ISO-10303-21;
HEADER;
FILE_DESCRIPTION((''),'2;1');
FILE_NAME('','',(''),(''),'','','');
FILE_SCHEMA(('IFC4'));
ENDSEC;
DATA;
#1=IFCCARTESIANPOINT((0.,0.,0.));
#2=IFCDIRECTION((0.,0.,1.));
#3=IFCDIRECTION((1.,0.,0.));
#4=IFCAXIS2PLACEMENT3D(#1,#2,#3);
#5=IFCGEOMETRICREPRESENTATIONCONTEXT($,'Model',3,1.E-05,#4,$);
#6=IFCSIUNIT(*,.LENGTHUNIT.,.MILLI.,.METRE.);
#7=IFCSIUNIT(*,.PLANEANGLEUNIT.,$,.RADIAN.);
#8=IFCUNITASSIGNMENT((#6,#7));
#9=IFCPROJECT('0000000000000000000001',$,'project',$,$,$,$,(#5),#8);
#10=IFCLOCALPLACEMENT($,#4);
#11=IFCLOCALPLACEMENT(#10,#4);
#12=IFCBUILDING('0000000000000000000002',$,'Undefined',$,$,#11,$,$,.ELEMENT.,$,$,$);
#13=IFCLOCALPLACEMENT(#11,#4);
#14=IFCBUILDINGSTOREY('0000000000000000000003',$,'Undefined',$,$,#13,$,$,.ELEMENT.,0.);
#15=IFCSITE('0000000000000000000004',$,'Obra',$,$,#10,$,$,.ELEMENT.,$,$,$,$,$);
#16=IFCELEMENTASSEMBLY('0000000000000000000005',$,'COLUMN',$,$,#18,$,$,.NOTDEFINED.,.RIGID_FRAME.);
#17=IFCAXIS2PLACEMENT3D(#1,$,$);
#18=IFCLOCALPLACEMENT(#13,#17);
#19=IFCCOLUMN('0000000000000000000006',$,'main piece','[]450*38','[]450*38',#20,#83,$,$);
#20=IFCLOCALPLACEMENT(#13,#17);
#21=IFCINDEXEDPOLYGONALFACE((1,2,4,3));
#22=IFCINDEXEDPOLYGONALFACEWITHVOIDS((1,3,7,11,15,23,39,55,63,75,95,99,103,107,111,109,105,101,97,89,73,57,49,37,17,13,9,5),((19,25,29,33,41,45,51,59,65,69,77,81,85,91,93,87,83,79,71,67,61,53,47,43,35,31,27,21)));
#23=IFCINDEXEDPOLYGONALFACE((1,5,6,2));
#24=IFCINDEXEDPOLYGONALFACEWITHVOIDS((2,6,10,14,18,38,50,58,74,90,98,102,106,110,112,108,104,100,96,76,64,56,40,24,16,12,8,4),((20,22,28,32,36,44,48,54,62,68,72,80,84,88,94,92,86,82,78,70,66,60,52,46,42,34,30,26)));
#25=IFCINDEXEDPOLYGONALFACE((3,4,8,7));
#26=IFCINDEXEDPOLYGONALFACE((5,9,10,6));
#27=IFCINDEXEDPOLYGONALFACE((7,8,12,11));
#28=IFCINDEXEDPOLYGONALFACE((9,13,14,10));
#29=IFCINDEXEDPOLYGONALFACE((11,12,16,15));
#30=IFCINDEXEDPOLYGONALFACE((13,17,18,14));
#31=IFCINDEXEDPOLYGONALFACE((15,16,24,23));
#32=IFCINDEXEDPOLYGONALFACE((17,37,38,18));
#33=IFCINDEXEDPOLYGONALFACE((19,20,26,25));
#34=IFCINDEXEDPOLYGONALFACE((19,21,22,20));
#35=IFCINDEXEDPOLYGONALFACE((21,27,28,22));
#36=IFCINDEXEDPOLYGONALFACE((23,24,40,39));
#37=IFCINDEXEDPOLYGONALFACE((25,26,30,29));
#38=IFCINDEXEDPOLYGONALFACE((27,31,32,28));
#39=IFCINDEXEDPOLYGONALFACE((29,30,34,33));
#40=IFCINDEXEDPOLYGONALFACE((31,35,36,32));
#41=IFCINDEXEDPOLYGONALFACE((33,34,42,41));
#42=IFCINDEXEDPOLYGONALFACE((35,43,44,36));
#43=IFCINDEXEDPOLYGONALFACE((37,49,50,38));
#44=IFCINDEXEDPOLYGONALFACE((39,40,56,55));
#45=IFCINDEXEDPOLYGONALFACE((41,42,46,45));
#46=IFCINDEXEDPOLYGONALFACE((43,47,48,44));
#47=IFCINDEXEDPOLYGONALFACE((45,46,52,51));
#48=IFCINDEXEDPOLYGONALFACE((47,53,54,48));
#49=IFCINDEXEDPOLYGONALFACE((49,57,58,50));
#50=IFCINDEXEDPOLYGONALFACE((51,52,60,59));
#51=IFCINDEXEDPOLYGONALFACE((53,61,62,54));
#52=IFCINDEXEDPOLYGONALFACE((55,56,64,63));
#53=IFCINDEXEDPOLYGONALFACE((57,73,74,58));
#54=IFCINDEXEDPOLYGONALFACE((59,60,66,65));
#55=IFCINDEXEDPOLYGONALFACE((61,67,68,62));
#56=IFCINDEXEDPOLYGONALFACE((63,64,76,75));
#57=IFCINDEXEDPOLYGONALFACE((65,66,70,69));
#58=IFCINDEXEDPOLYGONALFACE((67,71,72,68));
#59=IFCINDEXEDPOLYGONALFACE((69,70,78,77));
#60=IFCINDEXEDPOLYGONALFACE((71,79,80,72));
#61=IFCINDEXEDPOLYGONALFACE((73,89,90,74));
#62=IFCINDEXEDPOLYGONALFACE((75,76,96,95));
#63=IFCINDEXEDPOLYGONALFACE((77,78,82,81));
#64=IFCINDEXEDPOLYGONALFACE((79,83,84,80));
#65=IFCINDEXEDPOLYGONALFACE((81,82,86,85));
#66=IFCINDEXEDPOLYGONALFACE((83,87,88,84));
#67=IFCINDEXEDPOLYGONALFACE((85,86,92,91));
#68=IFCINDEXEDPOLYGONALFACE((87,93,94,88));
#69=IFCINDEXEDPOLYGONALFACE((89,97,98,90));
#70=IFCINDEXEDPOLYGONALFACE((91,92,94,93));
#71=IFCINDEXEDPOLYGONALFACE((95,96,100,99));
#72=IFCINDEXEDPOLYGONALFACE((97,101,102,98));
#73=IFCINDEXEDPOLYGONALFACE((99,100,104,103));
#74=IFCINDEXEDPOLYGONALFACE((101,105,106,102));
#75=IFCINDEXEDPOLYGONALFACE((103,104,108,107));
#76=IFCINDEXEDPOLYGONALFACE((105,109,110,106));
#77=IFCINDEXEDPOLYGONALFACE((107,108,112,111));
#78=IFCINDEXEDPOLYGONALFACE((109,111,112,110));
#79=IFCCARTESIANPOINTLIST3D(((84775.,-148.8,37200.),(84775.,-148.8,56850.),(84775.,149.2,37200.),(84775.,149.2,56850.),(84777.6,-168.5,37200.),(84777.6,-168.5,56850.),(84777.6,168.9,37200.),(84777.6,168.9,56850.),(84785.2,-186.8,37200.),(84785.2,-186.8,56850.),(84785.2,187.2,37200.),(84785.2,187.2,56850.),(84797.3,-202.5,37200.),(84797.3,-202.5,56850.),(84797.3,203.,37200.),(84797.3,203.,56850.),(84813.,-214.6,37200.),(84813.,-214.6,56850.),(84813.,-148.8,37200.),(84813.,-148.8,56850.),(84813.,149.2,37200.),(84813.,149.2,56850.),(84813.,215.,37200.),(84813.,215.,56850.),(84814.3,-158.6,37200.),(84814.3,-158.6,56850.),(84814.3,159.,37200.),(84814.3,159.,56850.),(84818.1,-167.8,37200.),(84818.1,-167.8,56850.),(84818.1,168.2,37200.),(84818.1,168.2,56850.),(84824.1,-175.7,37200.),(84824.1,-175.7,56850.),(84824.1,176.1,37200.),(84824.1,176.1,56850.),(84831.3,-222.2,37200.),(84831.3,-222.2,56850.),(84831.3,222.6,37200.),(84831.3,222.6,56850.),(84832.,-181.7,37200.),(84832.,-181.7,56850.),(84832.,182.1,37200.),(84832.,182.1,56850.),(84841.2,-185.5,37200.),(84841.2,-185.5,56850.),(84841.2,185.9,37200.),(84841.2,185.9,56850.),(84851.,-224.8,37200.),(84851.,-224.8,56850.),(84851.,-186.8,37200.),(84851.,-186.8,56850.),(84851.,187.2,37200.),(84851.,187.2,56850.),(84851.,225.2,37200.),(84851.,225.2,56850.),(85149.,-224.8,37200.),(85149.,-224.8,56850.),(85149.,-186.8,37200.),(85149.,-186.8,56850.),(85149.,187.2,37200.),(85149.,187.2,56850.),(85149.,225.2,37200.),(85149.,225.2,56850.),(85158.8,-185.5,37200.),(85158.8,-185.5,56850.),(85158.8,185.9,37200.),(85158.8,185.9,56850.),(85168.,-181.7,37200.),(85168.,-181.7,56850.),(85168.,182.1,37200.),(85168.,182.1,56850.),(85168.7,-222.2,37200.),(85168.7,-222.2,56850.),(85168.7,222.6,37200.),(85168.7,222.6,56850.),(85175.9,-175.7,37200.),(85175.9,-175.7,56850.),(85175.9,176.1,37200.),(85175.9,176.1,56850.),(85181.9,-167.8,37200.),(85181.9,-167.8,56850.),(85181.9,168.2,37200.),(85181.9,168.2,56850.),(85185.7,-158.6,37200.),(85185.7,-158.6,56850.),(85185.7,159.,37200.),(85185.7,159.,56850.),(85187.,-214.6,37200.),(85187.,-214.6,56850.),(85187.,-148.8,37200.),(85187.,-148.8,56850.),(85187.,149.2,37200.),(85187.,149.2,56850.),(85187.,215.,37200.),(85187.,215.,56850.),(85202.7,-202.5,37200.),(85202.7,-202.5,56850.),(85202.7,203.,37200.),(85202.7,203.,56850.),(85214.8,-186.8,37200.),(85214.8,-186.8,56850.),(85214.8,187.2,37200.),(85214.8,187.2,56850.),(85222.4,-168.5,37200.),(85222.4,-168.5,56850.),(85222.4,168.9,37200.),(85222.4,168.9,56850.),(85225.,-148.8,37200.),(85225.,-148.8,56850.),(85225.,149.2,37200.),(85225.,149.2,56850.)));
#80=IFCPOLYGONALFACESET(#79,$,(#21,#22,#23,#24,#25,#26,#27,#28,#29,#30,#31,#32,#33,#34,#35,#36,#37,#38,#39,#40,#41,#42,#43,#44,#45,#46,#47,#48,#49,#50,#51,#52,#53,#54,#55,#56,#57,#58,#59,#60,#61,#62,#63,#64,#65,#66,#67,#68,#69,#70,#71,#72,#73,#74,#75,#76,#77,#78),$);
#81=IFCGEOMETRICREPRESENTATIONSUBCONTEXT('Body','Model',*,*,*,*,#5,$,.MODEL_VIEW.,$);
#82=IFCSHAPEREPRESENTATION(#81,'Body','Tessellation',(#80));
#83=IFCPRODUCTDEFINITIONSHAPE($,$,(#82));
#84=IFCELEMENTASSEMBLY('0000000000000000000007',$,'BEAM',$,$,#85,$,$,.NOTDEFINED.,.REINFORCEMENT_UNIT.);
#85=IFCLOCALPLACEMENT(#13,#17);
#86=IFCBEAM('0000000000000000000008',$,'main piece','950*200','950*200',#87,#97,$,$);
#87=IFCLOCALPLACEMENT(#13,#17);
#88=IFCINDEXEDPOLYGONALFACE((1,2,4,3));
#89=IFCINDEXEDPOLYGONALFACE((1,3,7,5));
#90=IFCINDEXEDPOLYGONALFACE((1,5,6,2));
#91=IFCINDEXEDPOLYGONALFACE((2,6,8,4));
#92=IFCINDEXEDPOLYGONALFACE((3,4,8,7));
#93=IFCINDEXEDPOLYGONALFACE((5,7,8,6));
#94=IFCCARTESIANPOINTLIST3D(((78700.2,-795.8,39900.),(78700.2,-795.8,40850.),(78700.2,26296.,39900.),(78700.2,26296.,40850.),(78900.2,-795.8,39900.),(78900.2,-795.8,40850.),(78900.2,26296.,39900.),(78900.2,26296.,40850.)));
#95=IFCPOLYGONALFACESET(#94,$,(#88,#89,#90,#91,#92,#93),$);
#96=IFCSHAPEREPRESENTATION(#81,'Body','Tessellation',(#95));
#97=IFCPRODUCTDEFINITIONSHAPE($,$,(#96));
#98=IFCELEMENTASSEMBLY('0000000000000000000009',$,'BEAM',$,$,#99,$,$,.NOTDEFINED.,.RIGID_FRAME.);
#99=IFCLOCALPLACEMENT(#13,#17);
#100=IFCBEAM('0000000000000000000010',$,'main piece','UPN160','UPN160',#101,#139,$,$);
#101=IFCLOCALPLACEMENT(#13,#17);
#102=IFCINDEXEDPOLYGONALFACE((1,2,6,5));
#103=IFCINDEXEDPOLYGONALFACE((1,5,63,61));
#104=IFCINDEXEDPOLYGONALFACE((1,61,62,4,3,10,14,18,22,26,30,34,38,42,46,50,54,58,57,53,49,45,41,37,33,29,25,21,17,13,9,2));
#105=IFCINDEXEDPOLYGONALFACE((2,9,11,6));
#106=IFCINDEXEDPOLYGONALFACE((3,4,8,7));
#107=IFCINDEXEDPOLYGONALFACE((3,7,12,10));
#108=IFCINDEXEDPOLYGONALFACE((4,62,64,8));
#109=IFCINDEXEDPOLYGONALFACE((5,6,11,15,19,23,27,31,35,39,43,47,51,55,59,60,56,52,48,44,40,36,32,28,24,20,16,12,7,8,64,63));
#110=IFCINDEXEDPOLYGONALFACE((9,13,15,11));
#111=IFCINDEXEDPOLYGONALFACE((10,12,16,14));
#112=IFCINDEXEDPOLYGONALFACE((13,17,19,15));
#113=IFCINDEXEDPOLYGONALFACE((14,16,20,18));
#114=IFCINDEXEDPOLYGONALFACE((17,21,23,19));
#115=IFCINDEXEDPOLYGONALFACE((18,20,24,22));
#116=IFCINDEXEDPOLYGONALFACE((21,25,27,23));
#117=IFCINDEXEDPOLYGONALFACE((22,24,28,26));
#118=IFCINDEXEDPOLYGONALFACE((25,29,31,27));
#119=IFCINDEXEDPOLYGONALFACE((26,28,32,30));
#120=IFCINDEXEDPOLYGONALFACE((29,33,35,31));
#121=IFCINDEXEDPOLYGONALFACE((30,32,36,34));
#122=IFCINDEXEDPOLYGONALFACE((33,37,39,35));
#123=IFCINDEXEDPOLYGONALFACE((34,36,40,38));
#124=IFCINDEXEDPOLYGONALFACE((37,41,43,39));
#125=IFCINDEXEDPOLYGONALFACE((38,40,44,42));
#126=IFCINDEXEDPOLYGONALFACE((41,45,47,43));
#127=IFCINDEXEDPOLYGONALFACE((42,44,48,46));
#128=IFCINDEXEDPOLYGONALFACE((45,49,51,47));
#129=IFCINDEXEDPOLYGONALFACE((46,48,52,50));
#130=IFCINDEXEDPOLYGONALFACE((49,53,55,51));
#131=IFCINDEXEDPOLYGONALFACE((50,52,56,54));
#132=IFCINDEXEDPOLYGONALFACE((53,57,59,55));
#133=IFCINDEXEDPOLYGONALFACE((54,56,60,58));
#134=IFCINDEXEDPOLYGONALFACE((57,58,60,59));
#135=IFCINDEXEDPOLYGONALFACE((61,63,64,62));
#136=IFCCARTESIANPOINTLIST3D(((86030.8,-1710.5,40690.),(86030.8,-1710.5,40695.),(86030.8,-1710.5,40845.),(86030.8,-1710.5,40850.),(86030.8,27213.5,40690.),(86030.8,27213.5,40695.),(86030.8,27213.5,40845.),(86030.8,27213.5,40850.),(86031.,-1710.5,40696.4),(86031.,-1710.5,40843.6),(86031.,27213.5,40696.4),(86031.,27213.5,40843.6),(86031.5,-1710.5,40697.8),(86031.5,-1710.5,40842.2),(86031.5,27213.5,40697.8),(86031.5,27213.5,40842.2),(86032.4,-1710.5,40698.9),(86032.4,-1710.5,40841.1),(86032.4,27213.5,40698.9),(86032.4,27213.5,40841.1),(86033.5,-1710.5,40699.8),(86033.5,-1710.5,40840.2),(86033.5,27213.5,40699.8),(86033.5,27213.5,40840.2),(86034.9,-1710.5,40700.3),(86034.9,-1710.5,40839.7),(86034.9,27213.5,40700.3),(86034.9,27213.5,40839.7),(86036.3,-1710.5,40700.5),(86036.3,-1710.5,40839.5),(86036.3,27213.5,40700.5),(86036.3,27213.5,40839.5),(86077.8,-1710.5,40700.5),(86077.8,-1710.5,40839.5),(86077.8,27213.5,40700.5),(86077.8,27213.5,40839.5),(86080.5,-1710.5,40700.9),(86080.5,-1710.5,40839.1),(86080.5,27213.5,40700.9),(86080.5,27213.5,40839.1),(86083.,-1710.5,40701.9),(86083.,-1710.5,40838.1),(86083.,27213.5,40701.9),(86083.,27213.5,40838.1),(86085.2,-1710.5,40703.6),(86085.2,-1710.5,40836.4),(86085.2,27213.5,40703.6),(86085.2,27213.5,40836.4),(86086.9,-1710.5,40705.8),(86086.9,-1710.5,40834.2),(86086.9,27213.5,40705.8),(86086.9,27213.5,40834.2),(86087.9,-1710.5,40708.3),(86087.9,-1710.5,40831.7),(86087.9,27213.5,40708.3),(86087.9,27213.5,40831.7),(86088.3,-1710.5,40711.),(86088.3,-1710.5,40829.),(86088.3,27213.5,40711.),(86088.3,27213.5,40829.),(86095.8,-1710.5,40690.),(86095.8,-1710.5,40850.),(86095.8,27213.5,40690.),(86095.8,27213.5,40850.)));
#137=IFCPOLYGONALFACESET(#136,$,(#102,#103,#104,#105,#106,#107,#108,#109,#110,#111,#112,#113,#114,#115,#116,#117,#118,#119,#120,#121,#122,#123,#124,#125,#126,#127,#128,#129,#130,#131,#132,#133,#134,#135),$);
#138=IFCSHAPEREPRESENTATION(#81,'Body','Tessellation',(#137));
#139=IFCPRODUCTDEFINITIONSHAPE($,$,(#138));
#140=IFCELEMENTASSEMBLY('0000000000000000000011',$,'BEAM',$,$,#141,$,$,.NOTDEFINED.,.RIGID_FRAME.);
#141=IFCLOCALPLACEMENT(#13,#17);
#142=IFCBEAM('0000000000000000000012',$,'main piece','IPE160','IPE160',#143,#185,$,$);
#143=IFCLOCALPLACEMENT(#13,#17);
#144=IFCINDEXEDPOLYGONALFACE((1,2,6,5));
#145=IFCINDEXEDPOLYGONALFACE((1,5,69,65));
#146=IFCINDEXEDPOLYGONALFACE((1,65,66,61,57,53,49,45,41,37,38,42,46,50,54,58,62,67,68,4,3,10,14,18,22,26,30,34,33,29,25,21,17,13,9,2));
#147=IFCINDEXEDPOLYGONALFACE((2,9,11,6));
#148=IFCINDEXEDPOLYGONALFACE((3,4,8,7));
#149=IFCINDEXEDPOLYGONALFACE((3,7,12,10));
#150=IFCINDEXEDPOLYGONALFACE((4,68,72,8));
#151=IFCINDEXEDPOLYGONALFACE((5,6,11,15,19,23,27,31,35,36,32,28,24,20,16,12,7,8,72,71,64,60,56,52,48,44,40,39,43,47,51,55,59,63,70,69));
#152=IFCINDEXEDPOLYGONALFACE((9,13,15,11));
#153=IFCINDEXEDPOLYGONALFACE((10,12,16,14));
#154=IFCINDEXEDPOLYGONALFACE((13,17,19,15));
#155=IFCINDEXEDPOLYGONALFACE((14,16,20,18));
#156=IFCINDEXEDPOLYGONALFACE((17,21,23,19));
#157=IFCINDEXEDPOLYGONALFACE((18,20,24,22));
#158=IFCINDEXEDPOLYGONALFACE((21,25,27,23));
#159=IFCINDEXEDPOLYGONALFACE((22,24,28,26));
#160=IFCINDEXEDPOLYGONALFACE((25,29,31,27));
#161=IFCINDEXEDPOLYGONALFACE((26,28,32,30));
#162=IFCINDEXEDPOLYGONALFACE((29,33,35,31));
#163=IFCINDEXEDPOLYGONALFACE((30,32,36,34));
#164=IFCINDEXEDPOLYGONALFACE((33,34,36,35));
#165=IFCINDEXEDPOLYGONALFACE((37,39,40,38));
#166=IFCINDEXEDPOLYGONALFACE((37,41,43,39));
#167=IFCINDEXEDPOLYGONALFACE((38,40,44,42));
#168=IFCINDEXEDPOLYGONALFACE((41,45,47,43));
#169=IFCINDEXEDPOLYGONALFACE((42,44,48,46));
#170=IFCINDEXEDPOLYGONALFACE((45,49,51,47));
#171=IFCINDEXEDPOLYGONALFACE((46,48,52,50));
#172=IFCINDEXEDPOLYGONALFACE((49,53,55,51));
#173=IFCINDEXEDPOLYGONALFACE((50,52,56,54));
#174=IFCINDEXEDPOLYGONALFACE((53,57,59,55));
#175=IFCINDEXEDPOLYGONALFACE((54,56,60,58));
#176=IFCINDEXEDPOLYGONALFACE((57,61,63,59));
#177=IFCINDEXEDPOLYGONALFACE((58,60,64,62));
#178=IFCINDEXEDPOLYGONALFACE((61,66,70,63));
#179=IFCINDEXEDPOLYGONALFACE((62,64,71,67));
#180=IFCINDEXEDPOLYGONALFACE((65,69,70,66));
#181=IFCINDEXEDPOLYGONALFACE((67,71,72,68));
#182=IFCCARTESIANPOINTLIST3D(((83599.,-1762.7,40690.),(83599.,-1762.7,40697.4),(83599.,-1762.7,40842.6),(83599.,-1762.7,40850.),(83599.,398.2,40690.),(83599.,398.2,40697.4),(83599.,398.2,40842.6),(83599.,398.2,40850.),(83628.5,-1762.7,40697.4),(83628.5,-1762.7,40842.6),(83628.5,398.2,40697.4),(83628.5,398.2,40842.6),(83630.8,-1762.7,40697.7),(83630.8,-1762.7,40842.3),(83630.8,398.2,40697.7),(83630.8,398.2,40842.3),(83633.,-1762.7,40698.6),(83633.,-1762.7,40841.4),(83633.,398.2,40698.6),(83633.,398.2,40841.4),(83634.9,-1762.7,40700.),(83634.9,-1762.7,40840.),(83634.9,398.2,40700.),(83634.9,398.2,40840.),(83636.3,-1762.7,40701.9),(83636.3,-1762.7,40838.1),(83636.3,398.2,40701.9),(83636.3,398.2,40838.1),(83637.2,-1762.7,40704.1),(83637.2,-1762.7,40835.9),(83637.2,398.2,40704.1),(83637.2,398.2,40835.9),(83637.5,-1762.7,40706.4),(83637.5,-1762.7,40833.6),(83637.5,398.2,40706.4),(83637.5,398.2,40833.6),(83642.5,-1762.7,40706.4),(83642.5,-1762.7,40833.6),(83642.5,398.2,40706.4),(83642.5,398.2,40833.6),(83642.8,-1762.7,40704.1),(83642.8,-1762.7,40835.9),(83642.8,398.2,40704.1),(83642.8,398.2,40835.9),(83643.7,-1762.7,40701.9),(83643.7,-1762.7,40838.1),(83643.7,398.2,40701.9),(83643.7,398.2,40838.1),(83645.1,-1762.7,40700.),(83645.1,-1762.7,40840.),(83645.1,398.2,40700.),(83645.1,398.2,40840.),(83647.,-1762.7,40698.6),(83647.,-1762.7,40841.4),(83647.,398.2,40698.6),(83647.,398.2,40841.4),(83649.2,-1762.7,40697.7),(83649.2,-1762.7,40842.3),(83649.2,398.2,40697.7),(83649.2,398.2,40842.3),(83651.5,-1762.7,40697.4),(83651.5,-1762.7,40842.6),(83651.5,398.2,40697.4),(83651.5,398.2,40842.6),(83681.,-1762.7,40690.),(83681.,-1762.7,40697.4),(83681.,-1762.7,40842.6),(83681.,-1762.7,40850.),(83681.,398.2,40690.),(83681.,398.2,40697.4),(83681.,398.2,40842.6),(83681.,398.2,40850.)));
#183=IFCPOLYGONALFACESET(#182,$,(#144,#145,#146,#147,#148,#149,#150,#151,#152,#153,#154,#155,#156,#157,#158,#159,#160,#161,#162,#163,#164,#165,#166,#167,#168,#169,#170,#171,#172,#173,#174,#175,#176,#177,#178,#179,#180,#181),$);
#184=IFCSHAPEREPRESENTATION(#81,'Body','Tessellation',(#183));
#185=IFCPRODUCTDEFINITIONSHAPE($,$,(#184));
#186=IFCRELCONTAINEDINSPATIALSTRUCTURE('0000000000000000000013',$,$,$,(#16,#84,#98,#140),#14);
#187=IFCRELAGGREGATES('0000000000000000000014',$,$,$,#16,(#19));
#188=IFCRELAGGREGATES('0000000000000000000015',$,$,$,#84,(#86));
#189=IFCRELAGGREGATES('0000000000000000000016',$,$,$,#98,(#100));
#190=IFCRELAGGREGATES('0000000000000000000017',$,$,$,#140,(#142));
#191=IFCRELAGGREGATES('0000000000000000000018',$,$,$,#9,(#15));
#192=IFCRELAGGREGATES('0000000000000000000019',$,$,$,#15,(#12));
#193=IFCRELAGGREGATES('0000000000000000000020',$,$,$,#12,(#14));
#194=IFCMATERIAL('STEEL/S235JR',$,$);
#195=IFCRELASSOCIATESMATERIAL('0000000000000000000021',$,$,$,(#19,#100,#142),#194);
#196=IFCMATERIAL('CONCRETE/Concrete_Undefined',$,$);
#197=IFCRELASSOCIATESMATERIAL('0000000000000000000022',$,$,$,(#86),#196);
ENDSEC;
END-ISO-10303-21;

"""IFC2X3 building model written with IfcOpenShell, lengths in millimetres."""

from ifc_helpers import new_model, si_unit, frame, origin_with_axes, origin_2d_with_axis, place, context, subcontext, project, spatial, rectangle, hollow_rectangle, i_section, u_section, extrude, material, element, aggregate, save


model = new_model("IFC2X3")

# Units and contexts
model_context = context("Model", 3, precision=1e-05, world=origin_with_axes())
body_context = subcontext(model_context, "Body", "Model", "MODEL_VIEW")
ifc_project = project(units=[si_unit("LENGTHUNIT", "METRE", prefix="MILLI"), si_unit("PLANEANGLEUNIT", "RADIAN")], contexts=[model_context])

# Site, building, storey
site_placement = place(None, origin_with_axes())
site = spatial("IfcSite", under=ifc_project, at=site_placement, Name="Obra", CompositionType="ELEMENT")
building_placement = place(site_placement, origin_with_axes())
building = spatial("IfcBuilding", under=site, at=building_placement, Name="Undefined", CompositionType="ELEMENT")
storey_placement = place(building_placement, origin_with_axes())
storey = spatial("IfcBuildingStorey", under=building, at=storey_placement, Name="Undefined", CompositionType="ELEMENT", Elevation=0.0)

# Element assembly, column
assembly_1_placement = place(storey_placement, origin_with_axes())
assembly_1 = element("IfcElementAssembly", 1, at=assembly_1_placement, inside=storey, Name="COLUMN", AssemblyPlace="NOTDEFINED", PredefinedType="RIGID_FRAME")
ifc_material_1 = material(Name="STEEL/S235JR")
column_placement = place(assembly_1_placement, frame((85000.0, 0.2, 37200.0), z_axis=(0.0, 0.0, 1.0), x_axis=(0.0, 1.0, 0.0)))
column = element("IfcColumn", 2, at=column_placement, material=ifc_material_1, Name="main piece", Description="[]450*38", ObjectType="[]450*38", context=body_context, shape_type="SweptSolid", body=[
    extrude(hollow_rectangle(XDim=450.0, YDim=450.0, WallThickness=38.0, InnerFilletRadius=38.0, OuterFilletRadius=76.0, at=origin_2d_with_axis()), frame((0.0, 0.0, 19650.0), z_axis=(0.0, 0.0, -1.0), x_axis=(0.0, 1.0, 0.0)), (0.0, 0.0, 1.0), 19650.0),
])
aggregate(assembly_1, [column])

# Element assemblies, beams
assembly_2_placement = place(storey_placement, origin_with_axes())
assembly_2 = element("IfcElementAssembly", 3, at=assembly_2_placement, inside=storey, Name="BEAM", AssemblyPlace="NOTDEFINED", PredefinedType="REINFORCEMENT_UNIT")
ifc_material_2 = material(Name="CONCRETE/Concrete_Undefined")
beam_1_placement = place(assembly_2_placement, frame((78800.2, -795.8, 40375.0), z_axis=(0.0, 0.0, 1.0), x_axis=(0.0, 1.0, 0.0)))
beam_1 = element("IfcBeam", 4, at=beam_1_placement, material=ifc_material_2, Name="main piece", Description="950*200", ObjectType="950*200", context=body_context, shape_type="SweptSolid", body=[
    extrude(rectangle(XDim=200.0, YDim=950.0, at=origin_2d_with_axis()), frame((27091.8, 0.0, 0.0), z_axis=(-1.0, 0.0, 0.0), x_axis=(0.0, -1.0, 0.0)), (0.0, 0.0, 1.0), 27091.8),
])
aggregate(assembly_2, [beam_1])
assembly_3_placement = place(storey_placement, origin_with_axes())
assembly_3 = element("IfcElementAssembly", 5, at=assembly_3_placement, inside=storey, Name="BEAM", AssemblyPlace="NOTDEFINED", PredefinedType="RIGID_FRAME")
beam_2_placement = place(assembly_3_placement, frame((86063.3, -1710.5, 40770.0), z_axis=(0.0, 0.0, -1.0), x_axis=(0.0, 1.0, 0.0)))
beam_2 = element("IfcBeam", 6, at=beam_2_placement, material=ifc_material_1, Name="main piece", Description="UPN160", ObjectType="UPN160", context=body_context, shape_type="SweptSolid", body=[
    extrude(u_section(Depth=160.0, FlangeWidth=65.0, WebThickness=7.5, FlangeThickness=10.5, FilletRadius=10.5, EdgeRadius=5.5, at=origin_2d_with_axis()), frame((28924.0, 0.0, 0.0), z_axis=(-1.0, 0.0, 0.0), x_axis=(0.0, -1.0, 0.0)), (0.0, 0.0, 1.0), 28924.0),
])
aggregate(assembly_3, [beam_2])
assembly_4_placement = place(storey_placement, origin_with_axes())
assembly_4 = element("IfcElementAssembly", 7, at=assembly_4_placement, inside=storey, Name="BEAM", AssemblyPlace="NOTDEFINED", PredefinedType="RIGID_FRAME")
beam_3_placement = place(assembly_4_placement, frame((83640.0, 398.3, 40770.0), z_axis=(0.0, 0.0, 1.0), x_axis=(0.0, -1.0, 0.0)))
beam_3 = element("IfcBeam", 8, at=beam_3_placement, material=ifc_material_1, Name="main piece", Description="IPE160", ObjectType="IPE160", context=body_context, shape_type="SweptSolid", body=[
    extrude(i_section(OverallWidth=82.0, OverallDepth=160.0, WebThickness=5.0, FlangeThickness=7.4, FilletRadius=9.0, at=origin_2d_with_axis()), frame((2161.0, 0.0, 0.0), z_axis=(-1.0, 0.0, 0.0), x_axis=(0.0, -1.0, 0.0)), (0.0, 0.0, 1.0), 2160.9),
])
aggregate(assembly_4, [beam_3])

save(model, "model.ifc")
